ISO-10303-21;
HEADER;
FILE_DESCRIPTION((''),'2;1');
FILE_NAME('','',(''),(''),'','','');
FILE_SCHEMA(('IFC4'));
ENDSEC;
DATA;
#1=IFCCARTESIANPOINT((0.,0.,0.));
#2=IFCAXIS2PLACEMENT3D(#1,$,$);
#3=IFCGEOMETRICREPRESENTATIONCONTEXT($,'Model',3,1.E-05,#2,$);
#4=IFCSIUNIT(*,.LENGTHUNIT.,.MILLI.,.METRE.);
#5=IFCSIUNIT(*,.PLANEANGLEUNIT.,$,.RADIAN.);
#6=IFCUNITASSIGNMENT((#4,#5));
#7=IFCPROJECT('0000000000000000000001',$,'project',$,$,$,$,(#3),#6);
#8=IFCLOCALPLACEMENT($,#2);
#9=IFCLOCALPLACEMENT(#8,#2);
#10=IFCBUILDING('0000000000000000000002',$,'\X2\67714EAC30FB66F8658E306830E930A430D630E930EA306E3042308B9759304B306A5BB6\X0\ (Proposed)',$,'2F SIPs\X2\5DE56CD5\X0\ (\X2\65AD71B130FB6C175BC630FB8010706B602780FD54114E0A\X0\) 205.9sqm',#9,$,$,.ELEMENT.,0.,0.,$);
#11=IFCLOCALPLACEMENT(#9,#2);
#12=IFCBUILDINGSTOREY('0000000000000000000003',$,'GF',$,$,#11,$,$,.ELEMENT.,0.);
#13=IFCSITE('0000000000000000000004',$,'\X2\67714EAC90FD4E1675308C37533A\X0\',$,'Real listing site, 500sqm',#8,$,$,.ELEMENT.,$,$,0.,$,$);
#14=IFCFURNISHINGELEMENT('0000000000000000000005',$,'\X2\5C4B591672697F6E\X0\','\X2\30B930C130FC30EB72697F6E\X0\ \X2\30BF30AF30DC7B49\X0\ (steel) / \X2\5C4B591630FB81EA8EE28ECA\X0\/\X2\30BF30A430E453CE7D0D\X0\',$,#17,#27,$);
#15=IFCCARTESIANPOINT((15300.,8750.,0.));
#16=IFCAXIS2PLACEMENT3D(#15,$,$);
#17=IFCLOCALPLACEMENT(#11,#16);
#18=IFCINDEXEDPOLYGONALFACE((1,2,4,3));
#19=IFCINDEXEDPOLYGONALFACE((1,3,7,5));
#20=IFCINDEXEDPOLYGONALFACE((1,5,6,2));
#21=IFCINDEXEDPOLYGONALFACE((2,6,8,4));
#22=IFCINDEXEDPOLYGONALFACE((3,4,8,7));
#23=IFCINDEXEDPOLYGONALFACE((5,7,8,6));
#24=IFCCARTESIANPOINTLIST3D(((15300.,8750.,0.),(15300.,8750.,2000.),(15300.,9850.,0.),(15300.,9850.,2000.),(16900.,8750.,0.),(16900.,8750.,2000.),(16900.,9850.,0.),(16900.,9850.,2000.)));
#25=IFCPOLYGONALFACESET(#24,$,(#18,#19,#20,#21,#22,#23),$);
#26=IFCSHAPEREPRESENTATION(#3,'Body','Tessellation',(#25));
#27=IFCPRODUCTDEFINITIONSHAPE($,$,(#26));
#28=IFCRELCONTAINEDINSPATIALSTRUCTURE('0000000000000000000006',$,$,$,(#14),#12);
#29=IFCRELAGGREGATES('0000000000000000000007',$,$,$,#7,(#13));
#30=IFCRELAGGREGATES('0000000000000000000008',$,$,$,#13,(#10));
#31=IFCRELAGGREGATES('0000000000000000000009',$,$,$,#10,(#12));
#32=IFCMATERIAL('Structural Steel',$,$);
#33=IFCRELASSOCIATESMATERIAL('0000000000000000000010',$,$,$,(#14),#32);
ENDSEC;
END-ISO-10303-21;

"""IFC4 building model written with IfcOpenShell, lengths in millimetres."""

from ifc_helpers import new_model, si_unit, frame, frame_2d, origin, place, context, project, spatial, rectangle, extrude, material, element, save


model = new_model("IFC4")

# Units and contexts
model_context = context("Model", 3, precision=1e-05, world=origin())
ifc_project = project(units=[si_unit("LENGTHUNIT", "METRE", prefix="MILLI"), si_unit("PLANEANGLEUNIT", "RADIAN")], contexts=[model_context])

# Site, building, storey
site_placement = place(None, origin())
site = spatial("IfcSite", under=ifc_project, at=site_placement, Name="東京都世田谷区", ObjectType="Real listing site, 500sqm", CompositionType="ELEMENT", RefElevation=0.0)
building_placement = place(site_placement, origin())
building = spatial("IfcBuilding", under=site, at=building_placement, Name="東京・書斎とライブラリのある静かな家 (Proposed)", ObjectType="2F SIPs工法 (断熱・気密・耐火性能向上) 205.9sqm", CompositionType="ELEMENT", ElevationOfRefHeight=0.0, ElevationOfTerrain=0.0)
storey_placement = place(building_placement, origin())
storey = spatial("IfcBuildingStorey", under=building, at=storey_placement, Name="GF", CompositionType="ELEMENT", Elevation=0.0)

# Shared definitions
ifc_material_1 = material(Name="Structural Steel")

# Furnishing element
furnishing_1_placement = place(storey_placement, frame((15300.0, 8750.0, 0.0)))
element("IfcFurnishingElement", 1, at=furnishing_1_placement, inside=storey, material=ifc_material_1, Name="屋外物置", Description="スチール物置 タクボ等 (steel) / 屋外・自転車/タイヤ収納", context=model_context, shape_type="SweptSolid", body=[
    extrude(rectangle(XDim=1600.0, YDim=1100.0, at=frame_2d((800.0, 550.0))), frame((15300.0, 8750.0, 0.0)), (0.0, 0.0, 1.0), 2000.0),
])

save(model, "model.ifc")
